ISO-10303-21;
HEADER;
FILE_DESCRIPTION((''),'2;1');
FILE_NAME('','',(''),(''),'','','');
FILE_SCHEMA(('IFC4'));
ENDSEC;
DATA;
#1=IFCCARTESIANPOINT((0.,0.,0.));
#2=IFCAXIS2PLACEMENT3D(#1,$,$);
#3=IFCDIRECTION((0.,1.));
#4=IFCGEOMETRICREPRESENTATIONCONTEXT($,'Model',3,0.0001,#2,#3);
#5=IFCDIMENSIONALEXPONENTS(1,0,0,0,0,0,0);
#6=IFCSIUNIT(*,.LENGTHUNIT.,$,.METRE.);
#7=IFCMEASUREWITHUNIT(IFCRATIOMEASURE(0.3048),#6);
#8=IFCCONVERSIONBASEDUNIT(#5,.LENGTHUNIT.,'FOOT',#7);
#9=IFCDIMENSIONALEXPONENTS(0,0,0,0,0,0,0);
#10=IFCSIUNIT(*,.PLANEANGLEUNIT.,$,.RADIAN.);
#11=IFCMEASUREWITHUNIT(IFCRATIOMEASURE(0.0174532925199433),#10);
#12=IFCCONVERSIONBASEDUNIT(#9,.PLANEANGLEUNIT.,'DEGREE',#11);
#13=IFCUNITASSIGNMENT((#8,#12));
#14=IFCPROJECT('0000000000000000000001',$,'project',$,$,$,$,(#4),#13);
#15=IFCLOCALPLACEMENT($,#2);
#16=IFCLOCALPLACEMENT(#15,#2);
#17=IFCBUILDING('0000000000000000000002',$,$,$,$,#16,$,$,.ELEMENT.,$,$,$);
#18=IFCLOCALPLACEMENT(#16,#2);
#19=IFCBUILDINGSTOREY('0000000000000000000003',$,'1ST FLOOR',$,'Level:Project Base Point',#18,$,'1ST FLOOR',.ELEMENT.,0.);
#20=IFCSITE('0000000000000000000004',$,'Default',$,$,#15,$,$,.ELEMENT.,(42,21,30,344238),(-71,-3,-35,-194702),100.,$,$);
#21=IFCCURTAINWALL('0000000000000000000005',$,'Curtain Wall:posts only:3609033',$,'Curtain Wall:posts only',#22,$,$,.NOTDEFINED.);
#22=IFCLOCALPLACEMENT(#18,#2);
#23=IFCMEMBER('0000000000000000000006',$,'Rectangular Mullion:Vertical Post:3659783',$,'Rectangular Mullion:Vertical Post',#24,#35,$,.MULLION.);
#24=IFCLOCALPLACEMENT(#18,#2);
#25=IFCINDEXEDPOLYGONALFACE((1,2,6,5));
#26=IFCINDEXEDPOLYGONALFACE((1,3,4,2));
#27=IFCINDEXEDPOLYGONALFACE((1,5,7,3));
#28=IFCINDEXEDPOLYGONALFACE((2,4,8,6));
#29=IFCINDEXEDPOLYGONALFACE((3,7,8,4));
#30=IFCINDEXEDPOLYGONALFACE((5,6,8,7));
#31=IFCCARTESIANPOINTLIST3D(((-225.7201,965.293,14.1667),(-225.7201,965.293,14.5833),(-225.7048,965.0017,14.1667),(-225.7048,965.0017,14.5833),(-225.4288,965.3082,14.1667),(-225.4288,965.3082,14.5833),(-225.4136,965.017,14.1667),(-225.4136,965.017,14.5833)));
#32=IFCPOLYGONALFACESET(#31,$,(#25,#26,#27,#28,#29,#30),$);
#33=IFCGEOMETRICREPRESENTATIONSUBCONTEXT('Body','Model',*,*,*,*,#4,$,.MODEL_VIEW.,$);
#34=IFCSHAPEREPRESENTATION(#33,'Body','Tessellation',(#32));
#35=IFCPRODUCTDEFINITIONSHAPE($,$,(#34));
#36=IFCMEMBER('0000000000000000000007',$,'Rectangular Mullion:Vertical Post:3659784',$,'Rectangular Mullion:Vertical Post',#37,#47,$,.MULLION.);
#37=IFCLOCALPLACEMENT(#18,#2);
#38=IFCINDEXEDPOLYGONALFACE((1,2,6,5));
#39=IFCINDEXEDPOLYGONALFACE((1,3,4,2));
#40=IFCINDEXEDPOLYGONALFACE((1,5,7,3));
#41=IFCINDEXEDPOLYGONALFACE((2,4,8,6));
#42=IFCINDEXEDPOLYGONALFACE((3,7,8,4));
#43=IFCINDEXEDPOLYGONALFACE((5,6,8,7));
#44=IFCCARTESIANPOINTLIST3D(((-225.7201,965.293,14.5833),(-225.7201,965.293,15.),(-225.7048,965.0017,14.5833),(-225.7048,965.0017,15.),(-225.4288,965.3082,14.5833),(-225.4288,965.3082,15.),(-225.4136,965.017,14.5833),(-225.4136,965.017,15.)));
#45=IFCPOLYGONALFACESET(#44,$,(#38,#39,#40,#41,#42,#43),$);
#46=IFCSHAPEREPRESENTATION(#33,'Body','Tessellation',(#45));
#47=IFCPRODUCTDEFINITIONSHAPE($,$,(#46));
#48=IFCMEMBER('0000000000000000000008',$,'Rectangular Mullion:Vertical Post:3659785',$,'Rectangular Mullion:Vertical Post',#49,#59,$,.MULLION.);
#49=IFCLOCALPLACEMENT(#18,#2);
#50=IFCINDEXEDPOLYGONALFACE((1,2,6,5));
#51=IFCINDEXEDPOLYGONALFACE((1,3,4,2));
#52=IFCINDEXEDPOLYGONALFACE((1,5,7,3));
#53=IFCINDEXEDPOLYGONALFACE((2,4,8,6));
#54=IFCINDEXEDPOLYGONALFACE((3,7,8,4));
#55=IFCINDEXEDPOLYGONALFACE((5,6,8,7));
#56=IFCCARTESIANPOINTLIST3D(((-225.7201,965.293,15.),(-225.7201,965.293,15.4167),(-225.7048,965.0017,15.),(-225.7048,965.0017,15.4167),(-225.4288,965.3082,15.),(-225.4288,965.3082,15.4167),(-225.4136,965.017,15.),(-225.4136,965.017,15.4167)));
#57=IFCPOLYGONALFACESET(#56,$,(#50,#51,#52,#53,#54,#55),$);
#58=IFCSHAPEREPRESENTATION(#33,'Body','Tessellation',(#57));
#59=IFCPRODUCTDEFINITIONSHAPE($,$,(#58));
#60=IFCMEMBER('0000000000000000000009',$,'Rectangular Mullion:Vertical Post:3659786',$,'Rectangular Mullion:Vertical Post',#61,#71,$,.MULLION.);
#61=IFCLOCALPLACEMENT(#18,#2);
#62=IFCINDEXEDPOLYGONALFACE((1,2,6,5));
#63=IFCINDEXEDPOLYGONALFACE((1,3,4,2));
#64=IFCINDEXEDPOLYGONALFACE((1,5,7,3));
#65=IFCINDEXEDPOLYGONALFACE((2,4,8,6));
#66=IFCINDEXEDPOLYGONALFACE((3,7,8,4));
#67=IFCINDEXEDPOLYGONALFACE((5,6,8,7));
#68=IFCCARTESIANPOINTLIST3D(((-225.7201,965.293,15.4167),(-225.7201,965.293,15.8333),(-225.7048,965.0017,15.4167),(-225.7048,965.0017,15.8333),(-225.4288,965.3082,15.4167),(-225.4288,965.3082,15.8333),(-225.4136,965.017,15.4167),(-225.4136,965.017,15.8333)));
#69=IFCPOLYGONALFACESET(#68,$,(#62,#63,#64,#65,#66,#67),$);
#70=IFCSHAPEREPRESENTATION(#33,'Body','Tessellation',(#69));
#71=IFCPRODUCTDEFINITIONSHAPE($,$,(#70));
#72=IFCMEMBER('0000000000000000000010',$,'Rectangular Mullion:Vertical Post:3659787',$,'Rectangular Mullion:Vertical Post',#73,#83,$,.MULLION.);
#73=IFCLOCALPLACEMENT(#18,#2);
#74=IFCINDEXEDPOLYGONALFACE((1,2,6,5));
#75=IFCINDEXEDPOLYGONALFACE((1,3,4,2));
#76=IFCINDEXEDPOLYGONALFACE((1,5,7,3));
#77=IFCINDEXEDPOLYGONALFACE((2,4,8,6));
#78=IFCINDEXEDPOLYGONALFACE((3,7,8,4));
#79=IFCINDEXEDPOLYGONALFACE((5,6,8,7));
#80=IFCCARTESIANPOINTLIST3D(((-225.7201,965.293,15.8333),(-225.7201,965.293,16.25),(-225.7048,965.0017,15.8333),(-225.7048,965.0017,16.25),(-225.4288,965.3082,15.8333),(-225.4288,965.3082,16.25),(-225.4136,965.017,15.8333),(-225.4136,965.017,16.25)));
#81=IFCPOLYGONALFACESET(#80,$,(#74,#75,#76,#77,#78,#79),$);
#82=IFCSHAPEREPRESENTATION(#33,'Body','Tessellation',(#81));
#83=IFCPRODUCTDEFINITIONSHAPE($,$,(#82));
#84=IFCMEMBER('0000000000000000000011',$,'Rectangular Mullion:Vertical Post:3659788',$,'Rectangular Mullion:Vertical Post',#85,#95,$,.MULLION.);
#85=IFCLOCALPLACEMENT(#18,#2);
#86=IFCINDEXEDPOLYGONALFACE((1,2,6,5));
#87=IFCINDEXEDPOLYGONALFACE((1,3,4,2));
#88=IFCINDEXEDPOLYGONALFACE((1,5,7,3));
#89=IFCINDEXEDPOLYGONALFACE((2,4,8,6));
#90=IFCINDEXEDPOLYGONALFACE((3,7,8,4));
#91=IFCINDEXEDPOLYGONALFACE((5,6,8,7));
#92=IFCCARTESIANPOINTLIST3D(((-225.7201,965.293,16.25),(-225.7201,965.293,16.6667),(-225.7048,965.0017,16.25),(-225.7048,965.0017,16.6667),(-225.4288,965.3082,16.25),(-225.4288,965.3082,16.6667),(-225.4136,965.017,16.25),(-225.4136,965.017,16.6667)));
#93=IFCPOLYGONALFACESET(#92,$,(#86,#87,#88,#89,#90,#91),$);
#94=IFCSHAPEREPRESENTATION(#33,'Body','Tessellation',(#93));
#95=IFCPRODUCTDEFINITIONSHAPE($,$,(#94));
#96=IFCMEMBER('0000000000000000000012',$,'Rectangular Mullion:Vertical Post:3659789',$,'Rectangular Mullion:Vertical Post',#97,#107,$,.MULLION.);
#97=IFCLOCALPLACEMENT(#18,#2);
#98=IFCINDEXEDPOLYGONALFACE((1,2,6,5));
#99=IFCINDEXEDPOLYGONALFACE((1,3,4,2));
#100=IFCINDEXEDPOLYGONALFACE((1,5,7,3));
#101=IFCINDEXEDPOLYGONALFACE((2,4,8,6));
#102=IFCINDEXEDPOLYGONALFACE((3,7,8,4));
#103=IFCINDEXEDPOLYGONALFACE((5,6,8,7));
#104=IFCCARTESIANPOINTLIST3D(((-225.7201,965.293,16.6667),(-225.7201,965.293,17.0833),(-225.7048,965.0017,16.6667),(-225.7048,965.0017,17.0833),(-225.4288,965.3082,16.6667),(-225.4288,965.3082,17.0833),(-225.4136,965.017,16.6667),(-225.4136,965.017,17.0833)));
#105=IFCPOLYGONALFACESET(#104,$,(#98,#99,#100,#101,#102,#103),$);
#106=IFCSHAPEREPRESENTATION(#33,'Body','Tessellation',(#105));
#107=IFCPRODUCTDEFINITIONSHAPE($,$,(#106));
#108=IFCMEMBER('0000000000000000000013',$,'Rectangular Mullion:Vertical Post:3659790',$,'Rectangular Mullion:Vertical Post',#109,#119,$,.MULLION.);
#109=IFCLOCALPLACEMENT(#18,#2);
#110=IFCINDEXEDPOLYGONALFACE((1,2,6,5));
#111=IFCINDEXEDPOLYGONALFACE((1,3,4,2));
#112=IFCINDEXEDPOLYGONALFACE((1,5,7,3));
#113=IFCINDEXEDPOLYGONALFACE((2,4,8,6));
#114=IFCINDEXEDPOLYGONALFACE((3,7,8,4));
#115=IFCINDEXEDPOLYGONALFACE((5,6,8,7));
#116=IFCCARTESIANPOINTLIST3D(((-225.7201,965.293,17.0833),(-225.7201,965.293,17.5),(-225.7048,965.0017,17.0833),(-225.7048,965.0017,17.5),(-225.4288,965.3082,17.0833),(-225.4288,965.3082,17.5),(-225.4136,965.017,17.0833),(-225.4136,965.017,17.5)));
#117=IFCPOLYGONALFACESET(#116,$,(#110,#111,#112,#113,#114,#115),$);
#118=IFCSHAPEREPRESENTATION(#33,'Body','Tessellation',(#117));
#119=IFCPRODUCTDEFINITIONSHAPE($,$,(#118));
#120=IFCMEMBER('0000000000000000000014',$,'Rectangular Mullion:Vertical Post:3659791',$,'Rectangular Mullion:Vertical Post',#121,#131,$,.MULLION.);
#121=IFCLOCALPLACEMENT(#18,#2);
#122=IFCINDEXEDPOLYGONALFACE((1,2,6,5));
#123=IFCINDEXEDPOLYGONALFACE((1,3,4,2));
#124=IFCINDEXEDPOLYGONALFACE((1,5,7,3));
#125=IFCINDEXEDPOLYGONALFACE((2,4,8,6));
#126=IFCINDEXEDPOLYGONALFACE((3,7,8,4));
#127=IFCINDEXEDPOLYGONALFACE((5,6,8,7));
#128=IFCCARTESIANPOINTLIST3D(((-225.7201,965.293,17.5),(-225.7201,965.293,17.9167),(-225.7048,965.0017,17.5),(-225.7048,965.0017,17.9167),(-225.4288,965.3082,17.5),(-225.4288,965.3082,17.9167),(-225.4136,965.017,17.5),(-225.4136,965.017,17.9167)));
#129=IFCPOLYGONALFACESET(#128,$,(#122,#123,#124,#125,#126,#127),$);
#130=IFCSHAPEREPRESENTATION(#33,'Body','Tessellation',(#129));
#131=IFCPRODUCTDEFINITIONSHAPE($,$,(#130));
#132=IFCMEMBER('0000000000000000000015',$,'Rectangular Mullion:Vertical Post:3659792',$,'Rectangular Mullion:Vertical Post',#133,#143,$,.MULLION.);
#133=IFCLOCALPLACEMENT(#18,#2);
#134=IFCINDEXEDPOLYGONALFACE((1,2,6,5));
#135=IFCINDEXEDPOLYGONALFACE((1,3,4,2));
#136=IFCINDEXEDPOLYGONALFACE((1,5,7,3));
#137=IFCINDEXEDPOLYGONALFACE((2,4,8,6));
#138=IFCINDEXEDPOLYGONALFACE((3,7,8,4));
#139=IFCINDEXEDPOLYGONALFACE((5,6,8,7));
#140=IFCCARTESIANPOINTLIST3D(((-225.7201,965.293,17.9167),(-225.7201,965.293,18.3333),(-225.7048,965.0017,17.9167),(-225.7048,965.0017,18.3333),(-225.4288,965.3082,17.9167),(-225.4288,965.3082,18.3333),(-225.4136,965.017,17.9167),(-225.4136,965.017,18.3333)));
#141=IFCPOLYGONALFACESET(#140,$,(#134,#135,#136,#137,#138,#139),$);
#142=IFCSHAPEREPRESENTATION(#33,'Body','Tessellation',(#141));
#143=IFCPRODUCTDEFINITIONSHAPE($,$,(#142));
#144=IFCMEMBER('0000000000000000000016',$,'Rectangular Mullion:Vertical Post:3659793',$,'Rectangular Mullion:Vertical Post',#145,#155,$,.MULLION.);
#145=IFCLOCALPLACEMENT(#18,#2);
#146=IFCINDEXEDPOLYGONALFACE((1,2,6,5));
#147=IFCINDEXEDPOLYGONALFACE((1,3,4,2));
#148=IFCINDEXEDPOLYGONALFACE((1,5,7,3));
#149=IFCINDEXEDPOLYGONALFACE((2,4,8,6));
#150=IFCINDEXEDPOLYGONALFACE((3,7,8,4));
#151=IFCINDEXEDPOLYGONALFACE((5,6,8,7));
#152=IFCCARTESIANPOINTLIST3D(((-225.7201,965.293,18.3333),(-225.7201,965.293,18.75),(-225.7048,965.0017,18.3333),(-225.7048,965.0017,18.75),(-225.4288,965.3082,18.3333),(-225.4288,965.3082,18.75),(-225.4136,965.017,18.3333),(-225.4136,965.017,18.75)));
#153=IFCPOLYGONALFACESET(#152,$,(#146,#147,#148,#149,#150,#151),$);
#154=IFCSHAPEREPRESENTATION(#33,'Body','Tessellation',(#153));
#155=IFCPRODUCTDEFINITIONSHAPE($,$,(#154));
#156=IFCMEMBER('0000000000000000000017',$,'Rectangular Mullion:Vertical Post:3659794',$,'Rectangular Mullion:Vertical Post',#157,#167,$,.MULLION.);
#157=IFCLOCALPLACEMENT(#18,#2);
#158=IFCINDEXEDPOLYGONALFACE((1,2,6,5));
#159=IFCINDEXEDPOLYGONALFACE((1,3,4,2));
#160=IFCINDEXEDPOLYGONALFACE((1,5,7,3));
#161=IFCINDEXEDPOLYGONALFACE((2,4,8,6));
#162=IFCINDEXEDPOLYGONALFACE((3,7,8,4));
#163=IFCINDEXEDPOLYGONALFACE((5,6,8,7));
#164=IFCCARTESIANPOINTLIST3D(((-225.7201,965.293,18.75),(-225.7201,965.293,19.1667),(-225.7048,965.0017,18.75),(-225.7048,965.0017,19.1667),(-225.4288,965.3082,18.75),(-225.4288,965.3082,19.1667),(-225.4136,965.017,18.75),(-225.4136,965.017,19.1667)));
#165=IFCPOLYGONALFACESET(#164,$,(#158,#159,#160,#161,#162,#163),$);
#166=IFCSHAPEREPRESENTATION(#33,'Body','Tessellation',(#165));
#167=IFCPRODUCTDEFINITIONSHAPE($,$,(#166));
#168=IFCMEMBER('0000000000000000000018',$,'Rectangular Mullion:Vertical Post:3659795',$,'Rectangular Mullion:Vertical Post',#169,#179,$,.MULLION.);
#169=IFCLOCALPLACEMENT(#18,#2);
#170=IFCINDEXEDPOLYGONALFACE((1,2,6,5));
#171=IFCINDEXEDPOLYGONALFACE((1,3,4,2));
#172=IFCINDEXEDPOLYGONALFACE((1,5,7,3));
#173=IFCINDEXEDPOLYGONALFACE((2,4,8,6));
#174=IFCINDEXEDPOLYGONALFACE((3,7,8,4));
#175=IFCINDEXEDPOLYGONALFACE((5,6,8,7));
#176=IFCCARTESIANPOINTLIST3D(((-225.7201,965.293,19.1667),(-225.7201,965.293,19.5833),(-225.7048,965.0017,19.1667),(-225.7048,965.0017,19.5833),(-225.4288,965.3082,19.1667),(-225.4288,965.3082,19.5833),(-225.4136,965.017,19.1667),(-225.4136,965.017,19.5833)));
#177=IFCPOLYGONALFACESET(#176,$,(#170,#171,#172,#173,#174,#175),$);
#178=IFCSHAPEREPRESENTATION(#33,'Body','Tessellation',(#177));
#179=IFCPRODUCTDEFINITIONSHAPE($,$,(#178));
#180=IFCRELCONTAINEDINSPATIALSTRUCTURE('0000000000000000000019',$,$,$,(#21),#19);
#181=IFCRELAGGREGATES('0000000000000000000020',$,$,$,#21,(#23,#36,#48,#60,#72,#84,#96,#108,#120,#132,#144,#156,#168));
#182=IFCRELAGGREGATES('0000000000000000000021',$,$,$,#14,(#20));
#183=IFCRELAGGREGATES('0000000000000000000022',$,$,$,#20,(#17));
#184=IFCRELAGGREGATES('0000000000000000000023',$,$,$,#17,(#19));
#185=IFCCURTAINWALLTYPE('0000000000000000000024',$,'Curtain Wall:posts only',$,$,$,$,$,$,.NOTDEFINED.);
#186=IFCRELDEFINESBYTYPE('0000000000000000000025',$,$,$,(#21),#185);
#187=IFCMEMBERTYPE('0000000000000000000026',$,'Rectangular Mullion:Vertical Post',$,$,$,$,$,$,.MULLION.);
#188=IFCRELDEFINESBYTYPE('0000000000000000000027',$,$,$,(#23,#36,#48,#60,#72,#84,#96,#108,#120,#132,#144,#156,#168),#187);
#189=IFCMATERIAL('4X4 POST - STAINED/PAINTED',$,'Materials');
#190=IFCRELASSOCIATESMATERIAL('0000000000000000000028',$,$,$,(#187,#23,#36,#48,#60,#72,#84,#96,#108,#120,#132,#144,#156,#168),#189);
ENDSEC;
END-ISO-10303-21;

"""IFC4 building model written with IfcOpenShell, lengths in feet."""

from ifc_helpers import new_model, entity, si_unit, converted_unit, direction, frame, origin, origin_2d_with_axis, place, context, subcontext, project, spatial, rectangle, extrude, source, transform, mapped, material, material_profile, profile_set, profile_usage, type_object, type_shapes, element, aggregate, save


model = new_model("IFC4")

# Units and contexts
model_context = context("Model", 3, precision=0.0001, world=origin(), true_north=direction((0.0, 1.0)))
body_context = subcontext(model_context, "Body", "Model", "MODEL_VIEW")
ifc_project = project(units=[converted_unit("LENGTHUNIT", "FOOT", entity("IfcRatioMeasure", 0.3048), si_unit("LENGTHUNIT", "METRE"), dimensions=[1, 0, 0, 0, 0, 0, 0]), converted_unit("PLANEANGLEUNIT", "DEGREE", entity("IfcRatioMeasure", 0.0174532925199433), si_unit("PLANEANGLEUNIT", "RADIAN"), dimensions=[0, 0, 0, 0, 0, 0, 0])], contexts=[model_context])

# Site, building, storey
site_placement = place(None, origin())
site = spatial("IfcSite", under=ifc_project, at=site_placement, Name="Default", CompositionType="ELEMENT", RefLatitude=(42, 21, 30, 344238), RefLongitude=(-71, -3, -35, -194702), RefElevation=100.0)
building_placement = place(site_placement, origin())
building = spatial("IfcBuilding", under=site, at=building_placement, CompositionType="ELEMENT")
storey_placement = place(building_placement, origin())
storey = spatial("IfcBuildingStorey", under=building, at=storey_placement, Name="1ST FLOOR", ObjectType="Level:Project Base Point", LongName="1ST FLOOR", CompositionType="ELEMENT", Elevation=0.0)

# Curtain wall, members
curtain_wall_type_1 = type_object("IfcCurtainWallType", Name="Curtain Wall:posts only", PredefinedType="NOTDEFINED")
curtain_wall_1_placement = place(storey_placement, origin())
curtain_wall_1 = element("IfcCurtainWall", 1, at=curtain_wall_1_placement, inside=storey, type_object=curtain_wall_type_1, Name="Curtain Wall:posts only:3609033", ObjectType="Curtain Wall:posts only", PredefinedType="NOTDEFINED")
ifc_material_1 = material(Name="4X4 POST - STAINED/PAINTED", Category="Materials")
ifc_material_profile_1 = material_profile(ifc_material_1, rectangle(XDim=0.2917, YDim=0.2917, at=origin_2d_with_axis()), Name="Vertical Post")
ifc_profile_set_1 = profile_set([ifc_material_profile_1], Name="Vertical Post")
ifc_profile_usage_1 = profile_usage(ifc_profile_set_1)
member_type_1 = type_object("IfcMemberType", Name="Rectangular Mullion:Vertical Post", PredefinedType="MULLION", material=ifc_profile_set_1)
shared_shape_1 = source(origin(), body_context, "Body", "SweptSolid", [
    extrude(rectangle(XDim=0.2917, YDim=0.2917, at=origin_2d_with_axis()), frame((0.0, -0.2083, -0.4167), z_axis=(0.0, 0.0, 1.0), x_axis=(0.0, -1.0, 0.0)), (0.0, 0.0, 1.0), 0.4167),
])
type_shapes(member_type_1, [shared_shape_1])
member_1_placement = place(storey_placement, frame((-225.5777, 965.363, 14.1667), z_axis=(0.0, 0.0, -1.0), x_axis=(-0.99863, -0.052336, 0.0)))
member_1 = element("IfcMember", 2, at=member_1_placement, type_object=member_type_1, material=ifc_profile_usage_1, Name="Rectangular Mullion:Vertical Post:3659783", ObjectType="Rectangular Mullion:Vertical Post", PredefinedType="MULLION", context=body_context, shape_type="MappedRepresentation", body=[
    mapped(shared_shape_1, transform((0.0, 0.0, 0.0), scale=1.0)),
])
ifc_profile_usage_2 = profile_usage(ifc_profile_set_1)
member_2_placement = place(storey_placement, frame((-225.5777, 965.363, 14.5833), z_axis=(0.0, 0.0, -1.0), x_axis=(-0.99863, -0.052336, 0.0)))
member_2 = element("IfcMember", 3, at=member_2_placement, type_object=member_type_1, material=ifc_profile_usage_2, Name="Rectangular Mullion:Vertical Post:3659784", ObjectType="Rectangular Mullion:Vertical Post", PredefinedType="MULLION", context=body_context, shape_type="MappedRepresentation", body=[
    mapped(shared_shape_1, transform((0.0, 0.0, 0.0), scale=1.0)),
])
ifc_profile_usage_3 = profile_usage(ifc_profile_set_1)
member_3_placement = place(storey_placement, frame((-225.5777, 965.363, 15.0), z_axis=(0.0, 0.0, -1.0), x_axis=(-0.99863, -0.052336, 0.0)))
member_3 = element("IfcMember", 4, at=member_3_placement, type_object=member_type_1, material=ifc_profile_usage_3, Name="Rectangular Mullion:Vertical Post:3659785", ObjectType="Rectangular Mullion:Vertical Post", PredefinedType="MULLION", context=body_context, shape_type="MappedRepresentation", body=[
    mapped(shared_shape_1, transform((0.0, 0.0, 0.0), scale=1.0)),
])
ifc_profile_usage_4 = profile_usage(ifc_profile_set_1)
member_4_placement = place(storey_placement, frame((-225.5777, 965.363, 15.4167), z_axis=(0.0, 0.0, -1.0), x_axis=(-0.99863, -0.052336, 0.0)))
member_4 = element("IfcMember", 5, at=member_4_placement, type_object=member_type_1, material=ifc_profile_usage_4, Name="Rectangular Mullion:Vertical Post:3659786", ObjectType="Rectangular Mullion:Vertical Post", PredefinedType="MULLION", context=body_context, shape_type="MappedRepresentation", body=[
    mapped(shared_shape_1, transform((0.0, 0.0, 0.0), scale=1.0)),
])
ifc_profile_usage_5 = profile_usage(ifc_profile_set_1)
member_5_placement = place(storey_placement, frame((-225.5777, 965.363, 15.8333), z_axis=(0.0, 0.0, -1.0), x_axis=(-0.99863, -0.052336, 0.0)))
member_5 = element("IfcMember", 6, at=member_5_placement, type_object=member_type_1, material=ifc_profile_usage_5, Name="Rectangular Mullion:Vertical Post:3659787", ObjectType="Rectangular Mullion:Vertical Post", PredefinedType="MULLION", context=body_context, shape_type="MappedRepresentation", body=[
    mapped(shared_shape_1, transform((0.0, 0.0, 0.0), scale=1.0)),
])
ifc_profile_usage_6 = profile_usage(ifc_profile_set_1)
member_6_placement = place(storey_placement, frame((-225.5777, 965.363, 16.25), z_axis=(0.0, 0.0, -1.0), x_axis=(-0.99863, -0.052336, 0.0)))
member_6 = element("IfcMember", 7, at=member_6_placement, type_object=member_type_1, material=ifc_profile_usage_6, Name="Rectangular Mullion:Vertical Post:3659788", ObjectType="Rectangular Mullion:Vertical Post", PredefinedType="MULLION", context=body_context, shape_type="MappedRepresentation", body=[
    mapped(shared_shape_1, transform((0.0, 0.0, 0.0), scale=1.0)),
])
ifc_profile_usage_7 = profile_usage(ifc_profile_set_1)
member_7_placement = place(storey_placement, frame((-225.5777, 965.363, 16.6667), z_axis=(0.0, 0.0, -1.0), x_axis=(-0.99863, -0.052336, 0.0)))
member_7 = element("IfcMember", 8, at=member_7_placement, type_object=member_type_1, material=ifc_profile_usage_7, Name="Rectangular Mullion:Vertical Post:3659789", ObjectType="Rectangular Mullion:Vertical Post", PredefinedType="MULLION", context=body_context, shape_type="MappedRepresentation", body=[
    mapped(shared_shape_1, transform((0.0, 0.0, 0.0), scale=1.0)),
])
ifc_profile_usage_8 = profile_usage(ifc_profile_set_1)
member_8_placement = place(storey_placement, frame((-225.5777, 965.363, 17.0833), z_axis=(0.0, 0.0, -1.0), x_axis=(-0.99863, -0.052336, 0.0)))
member_8 = element("IfcMember", 9, at=member_8_placement, type_object=member_type_1, material=ifc_profile_usage_8, Name="Rectangular Mullion:Vertical Post:3659790", ObjectType="Rectangular Mullion:Vertical Post", PredefinedType="MULLION", context=body_context, shape_type="MappedRepresentation", body=[
    mapped(shared_shape_1, transform((0.0, 0.0, 0.0), scale=1.0)),
])
ifc_profile_usage_9 = profile_usage(ifc_profile_set_1)
member_9_placement = place(storey_placement, frame((-225.5777, 965.363, 17.5), z_axis=(0.0, 0.0, -1.0), x_axis=(-0.99863, -0.052336, 0.0)))
member_9 = element("IfcMember", 10, at=member_9_placement, type_object=member_type_1, material=ifc_profile_usage_9, Name="Rectangular Mullion:Vertical Post:3659791", ObjectType="Rectangular Mullion:Vertical Post", PredefinedType="MULLION", context=body_context, shape_type="MappedRepresentation", body=[
    mapped(shared_shape_1, transform((0.0, 0.0, 0.0), scale=1.0)),
])
ifc_profile_usage_10 = profile_usage(ifc_profile_set_1)
member_10_placement = place(storey_placement, frame((-225.5777, 965.363, 17.9167), z_axis=(0.0, 0.0, -1.0), x_axis=(-0.99863, -0.052336, 0.0)))
member_10 = element("IfcMember", 11, at=member_10_placement, type_object=member_type_1, material=ifc_profile_usage_10, Name="Rectangular Mullion:Vertical Post:3659792", ObjectType="Rectangular Mullion:Vertical Post", PredefinedType="MULLION", context=body_context, shape_type="MappedRepresentation", body=[
    mapped(shared_shape_1, transform((0.0, 0.0, 0.0), scale=1.0)),
])
ifc_profile_usage_11 = profile_usage(ifc_profile_set_1)
member_11_placement = place(storey_placement, frame((-225.5777, 965.363, 18.3333), z_axis=(0.0, 0.0, -1.0), x_axis=(-0.99863, -0.052336, 0.0)))
member_11 = element("IfcMember", 12, at=member_11_placement, type_object=member_type_1, material=ifc_profile_usage_11, Name="Rectangular Mullion:Vertical Post:3659793", ObjectType="Rectangular Mullion:Vertical Post", PredefinedType="MULLION", context=body_context, shape_type="MappedRepresentation", body=[
    mapped(shared_shape_1, transform((0.0, 0.0, 0.0), scale=1.0)),
])
ifc_profile_usage_12 = profile_usage(ifc_profile_set_1)
member_12_placement = place(storey_placement, frame((-225.5777, 965.363, 18.75), z_axis=(0.0, 0.0, -1.0), x_axis=(-0.99863, -0.052336, 0.0)))
member_12 = element("IfcMember", 13, at=member_12_placement, type_object=member_type_1, material=ifc_profile_usage_12, Name="Rectangular Mullion:Vertical Post:3659794", ObjectType="Rectangular Mullion:Vertical Post", PredefinedType="MULLION", context=body_context, shape_type="MappedRepresentation", body=[
    mapped(shared_shape_1, transform((0.0, 0.0, 0.0), scale=1.0)),
])
ifc_profile_usage_13 = profile_usage(ifc_profile_set_1)
member_13_placement = place(storey_placement, frame((-225.5777, 965.363, 19.1667), z_axis=(0.0, 0.0, -1.0), x_axis=(-0.99863, -0.052336, 0.0)))
member_13 = element("IfcMember", 14, at=member_13_placement, type_object=member_type_1, material=ifc_profile_usage_13, Name="Rectangular Mullion:Vertical Post:3659795", ObjectType="Rectangular Mullion:Vertical Post", PredefinedType="MULLION", context=body_context, shape_type="MappedRepresentation", body=[
    mapped(shared_shape_1, transform((0.0, 0.0, 0.0), scale=1.0)),
])
aggregate(curtain_wall_1, [member_1, member_2, member_3, member_4, member_5, member_6, member_7, member_8, member_9, member_10, member_11, member_12, member_13])

save(model, "model.ifc")
